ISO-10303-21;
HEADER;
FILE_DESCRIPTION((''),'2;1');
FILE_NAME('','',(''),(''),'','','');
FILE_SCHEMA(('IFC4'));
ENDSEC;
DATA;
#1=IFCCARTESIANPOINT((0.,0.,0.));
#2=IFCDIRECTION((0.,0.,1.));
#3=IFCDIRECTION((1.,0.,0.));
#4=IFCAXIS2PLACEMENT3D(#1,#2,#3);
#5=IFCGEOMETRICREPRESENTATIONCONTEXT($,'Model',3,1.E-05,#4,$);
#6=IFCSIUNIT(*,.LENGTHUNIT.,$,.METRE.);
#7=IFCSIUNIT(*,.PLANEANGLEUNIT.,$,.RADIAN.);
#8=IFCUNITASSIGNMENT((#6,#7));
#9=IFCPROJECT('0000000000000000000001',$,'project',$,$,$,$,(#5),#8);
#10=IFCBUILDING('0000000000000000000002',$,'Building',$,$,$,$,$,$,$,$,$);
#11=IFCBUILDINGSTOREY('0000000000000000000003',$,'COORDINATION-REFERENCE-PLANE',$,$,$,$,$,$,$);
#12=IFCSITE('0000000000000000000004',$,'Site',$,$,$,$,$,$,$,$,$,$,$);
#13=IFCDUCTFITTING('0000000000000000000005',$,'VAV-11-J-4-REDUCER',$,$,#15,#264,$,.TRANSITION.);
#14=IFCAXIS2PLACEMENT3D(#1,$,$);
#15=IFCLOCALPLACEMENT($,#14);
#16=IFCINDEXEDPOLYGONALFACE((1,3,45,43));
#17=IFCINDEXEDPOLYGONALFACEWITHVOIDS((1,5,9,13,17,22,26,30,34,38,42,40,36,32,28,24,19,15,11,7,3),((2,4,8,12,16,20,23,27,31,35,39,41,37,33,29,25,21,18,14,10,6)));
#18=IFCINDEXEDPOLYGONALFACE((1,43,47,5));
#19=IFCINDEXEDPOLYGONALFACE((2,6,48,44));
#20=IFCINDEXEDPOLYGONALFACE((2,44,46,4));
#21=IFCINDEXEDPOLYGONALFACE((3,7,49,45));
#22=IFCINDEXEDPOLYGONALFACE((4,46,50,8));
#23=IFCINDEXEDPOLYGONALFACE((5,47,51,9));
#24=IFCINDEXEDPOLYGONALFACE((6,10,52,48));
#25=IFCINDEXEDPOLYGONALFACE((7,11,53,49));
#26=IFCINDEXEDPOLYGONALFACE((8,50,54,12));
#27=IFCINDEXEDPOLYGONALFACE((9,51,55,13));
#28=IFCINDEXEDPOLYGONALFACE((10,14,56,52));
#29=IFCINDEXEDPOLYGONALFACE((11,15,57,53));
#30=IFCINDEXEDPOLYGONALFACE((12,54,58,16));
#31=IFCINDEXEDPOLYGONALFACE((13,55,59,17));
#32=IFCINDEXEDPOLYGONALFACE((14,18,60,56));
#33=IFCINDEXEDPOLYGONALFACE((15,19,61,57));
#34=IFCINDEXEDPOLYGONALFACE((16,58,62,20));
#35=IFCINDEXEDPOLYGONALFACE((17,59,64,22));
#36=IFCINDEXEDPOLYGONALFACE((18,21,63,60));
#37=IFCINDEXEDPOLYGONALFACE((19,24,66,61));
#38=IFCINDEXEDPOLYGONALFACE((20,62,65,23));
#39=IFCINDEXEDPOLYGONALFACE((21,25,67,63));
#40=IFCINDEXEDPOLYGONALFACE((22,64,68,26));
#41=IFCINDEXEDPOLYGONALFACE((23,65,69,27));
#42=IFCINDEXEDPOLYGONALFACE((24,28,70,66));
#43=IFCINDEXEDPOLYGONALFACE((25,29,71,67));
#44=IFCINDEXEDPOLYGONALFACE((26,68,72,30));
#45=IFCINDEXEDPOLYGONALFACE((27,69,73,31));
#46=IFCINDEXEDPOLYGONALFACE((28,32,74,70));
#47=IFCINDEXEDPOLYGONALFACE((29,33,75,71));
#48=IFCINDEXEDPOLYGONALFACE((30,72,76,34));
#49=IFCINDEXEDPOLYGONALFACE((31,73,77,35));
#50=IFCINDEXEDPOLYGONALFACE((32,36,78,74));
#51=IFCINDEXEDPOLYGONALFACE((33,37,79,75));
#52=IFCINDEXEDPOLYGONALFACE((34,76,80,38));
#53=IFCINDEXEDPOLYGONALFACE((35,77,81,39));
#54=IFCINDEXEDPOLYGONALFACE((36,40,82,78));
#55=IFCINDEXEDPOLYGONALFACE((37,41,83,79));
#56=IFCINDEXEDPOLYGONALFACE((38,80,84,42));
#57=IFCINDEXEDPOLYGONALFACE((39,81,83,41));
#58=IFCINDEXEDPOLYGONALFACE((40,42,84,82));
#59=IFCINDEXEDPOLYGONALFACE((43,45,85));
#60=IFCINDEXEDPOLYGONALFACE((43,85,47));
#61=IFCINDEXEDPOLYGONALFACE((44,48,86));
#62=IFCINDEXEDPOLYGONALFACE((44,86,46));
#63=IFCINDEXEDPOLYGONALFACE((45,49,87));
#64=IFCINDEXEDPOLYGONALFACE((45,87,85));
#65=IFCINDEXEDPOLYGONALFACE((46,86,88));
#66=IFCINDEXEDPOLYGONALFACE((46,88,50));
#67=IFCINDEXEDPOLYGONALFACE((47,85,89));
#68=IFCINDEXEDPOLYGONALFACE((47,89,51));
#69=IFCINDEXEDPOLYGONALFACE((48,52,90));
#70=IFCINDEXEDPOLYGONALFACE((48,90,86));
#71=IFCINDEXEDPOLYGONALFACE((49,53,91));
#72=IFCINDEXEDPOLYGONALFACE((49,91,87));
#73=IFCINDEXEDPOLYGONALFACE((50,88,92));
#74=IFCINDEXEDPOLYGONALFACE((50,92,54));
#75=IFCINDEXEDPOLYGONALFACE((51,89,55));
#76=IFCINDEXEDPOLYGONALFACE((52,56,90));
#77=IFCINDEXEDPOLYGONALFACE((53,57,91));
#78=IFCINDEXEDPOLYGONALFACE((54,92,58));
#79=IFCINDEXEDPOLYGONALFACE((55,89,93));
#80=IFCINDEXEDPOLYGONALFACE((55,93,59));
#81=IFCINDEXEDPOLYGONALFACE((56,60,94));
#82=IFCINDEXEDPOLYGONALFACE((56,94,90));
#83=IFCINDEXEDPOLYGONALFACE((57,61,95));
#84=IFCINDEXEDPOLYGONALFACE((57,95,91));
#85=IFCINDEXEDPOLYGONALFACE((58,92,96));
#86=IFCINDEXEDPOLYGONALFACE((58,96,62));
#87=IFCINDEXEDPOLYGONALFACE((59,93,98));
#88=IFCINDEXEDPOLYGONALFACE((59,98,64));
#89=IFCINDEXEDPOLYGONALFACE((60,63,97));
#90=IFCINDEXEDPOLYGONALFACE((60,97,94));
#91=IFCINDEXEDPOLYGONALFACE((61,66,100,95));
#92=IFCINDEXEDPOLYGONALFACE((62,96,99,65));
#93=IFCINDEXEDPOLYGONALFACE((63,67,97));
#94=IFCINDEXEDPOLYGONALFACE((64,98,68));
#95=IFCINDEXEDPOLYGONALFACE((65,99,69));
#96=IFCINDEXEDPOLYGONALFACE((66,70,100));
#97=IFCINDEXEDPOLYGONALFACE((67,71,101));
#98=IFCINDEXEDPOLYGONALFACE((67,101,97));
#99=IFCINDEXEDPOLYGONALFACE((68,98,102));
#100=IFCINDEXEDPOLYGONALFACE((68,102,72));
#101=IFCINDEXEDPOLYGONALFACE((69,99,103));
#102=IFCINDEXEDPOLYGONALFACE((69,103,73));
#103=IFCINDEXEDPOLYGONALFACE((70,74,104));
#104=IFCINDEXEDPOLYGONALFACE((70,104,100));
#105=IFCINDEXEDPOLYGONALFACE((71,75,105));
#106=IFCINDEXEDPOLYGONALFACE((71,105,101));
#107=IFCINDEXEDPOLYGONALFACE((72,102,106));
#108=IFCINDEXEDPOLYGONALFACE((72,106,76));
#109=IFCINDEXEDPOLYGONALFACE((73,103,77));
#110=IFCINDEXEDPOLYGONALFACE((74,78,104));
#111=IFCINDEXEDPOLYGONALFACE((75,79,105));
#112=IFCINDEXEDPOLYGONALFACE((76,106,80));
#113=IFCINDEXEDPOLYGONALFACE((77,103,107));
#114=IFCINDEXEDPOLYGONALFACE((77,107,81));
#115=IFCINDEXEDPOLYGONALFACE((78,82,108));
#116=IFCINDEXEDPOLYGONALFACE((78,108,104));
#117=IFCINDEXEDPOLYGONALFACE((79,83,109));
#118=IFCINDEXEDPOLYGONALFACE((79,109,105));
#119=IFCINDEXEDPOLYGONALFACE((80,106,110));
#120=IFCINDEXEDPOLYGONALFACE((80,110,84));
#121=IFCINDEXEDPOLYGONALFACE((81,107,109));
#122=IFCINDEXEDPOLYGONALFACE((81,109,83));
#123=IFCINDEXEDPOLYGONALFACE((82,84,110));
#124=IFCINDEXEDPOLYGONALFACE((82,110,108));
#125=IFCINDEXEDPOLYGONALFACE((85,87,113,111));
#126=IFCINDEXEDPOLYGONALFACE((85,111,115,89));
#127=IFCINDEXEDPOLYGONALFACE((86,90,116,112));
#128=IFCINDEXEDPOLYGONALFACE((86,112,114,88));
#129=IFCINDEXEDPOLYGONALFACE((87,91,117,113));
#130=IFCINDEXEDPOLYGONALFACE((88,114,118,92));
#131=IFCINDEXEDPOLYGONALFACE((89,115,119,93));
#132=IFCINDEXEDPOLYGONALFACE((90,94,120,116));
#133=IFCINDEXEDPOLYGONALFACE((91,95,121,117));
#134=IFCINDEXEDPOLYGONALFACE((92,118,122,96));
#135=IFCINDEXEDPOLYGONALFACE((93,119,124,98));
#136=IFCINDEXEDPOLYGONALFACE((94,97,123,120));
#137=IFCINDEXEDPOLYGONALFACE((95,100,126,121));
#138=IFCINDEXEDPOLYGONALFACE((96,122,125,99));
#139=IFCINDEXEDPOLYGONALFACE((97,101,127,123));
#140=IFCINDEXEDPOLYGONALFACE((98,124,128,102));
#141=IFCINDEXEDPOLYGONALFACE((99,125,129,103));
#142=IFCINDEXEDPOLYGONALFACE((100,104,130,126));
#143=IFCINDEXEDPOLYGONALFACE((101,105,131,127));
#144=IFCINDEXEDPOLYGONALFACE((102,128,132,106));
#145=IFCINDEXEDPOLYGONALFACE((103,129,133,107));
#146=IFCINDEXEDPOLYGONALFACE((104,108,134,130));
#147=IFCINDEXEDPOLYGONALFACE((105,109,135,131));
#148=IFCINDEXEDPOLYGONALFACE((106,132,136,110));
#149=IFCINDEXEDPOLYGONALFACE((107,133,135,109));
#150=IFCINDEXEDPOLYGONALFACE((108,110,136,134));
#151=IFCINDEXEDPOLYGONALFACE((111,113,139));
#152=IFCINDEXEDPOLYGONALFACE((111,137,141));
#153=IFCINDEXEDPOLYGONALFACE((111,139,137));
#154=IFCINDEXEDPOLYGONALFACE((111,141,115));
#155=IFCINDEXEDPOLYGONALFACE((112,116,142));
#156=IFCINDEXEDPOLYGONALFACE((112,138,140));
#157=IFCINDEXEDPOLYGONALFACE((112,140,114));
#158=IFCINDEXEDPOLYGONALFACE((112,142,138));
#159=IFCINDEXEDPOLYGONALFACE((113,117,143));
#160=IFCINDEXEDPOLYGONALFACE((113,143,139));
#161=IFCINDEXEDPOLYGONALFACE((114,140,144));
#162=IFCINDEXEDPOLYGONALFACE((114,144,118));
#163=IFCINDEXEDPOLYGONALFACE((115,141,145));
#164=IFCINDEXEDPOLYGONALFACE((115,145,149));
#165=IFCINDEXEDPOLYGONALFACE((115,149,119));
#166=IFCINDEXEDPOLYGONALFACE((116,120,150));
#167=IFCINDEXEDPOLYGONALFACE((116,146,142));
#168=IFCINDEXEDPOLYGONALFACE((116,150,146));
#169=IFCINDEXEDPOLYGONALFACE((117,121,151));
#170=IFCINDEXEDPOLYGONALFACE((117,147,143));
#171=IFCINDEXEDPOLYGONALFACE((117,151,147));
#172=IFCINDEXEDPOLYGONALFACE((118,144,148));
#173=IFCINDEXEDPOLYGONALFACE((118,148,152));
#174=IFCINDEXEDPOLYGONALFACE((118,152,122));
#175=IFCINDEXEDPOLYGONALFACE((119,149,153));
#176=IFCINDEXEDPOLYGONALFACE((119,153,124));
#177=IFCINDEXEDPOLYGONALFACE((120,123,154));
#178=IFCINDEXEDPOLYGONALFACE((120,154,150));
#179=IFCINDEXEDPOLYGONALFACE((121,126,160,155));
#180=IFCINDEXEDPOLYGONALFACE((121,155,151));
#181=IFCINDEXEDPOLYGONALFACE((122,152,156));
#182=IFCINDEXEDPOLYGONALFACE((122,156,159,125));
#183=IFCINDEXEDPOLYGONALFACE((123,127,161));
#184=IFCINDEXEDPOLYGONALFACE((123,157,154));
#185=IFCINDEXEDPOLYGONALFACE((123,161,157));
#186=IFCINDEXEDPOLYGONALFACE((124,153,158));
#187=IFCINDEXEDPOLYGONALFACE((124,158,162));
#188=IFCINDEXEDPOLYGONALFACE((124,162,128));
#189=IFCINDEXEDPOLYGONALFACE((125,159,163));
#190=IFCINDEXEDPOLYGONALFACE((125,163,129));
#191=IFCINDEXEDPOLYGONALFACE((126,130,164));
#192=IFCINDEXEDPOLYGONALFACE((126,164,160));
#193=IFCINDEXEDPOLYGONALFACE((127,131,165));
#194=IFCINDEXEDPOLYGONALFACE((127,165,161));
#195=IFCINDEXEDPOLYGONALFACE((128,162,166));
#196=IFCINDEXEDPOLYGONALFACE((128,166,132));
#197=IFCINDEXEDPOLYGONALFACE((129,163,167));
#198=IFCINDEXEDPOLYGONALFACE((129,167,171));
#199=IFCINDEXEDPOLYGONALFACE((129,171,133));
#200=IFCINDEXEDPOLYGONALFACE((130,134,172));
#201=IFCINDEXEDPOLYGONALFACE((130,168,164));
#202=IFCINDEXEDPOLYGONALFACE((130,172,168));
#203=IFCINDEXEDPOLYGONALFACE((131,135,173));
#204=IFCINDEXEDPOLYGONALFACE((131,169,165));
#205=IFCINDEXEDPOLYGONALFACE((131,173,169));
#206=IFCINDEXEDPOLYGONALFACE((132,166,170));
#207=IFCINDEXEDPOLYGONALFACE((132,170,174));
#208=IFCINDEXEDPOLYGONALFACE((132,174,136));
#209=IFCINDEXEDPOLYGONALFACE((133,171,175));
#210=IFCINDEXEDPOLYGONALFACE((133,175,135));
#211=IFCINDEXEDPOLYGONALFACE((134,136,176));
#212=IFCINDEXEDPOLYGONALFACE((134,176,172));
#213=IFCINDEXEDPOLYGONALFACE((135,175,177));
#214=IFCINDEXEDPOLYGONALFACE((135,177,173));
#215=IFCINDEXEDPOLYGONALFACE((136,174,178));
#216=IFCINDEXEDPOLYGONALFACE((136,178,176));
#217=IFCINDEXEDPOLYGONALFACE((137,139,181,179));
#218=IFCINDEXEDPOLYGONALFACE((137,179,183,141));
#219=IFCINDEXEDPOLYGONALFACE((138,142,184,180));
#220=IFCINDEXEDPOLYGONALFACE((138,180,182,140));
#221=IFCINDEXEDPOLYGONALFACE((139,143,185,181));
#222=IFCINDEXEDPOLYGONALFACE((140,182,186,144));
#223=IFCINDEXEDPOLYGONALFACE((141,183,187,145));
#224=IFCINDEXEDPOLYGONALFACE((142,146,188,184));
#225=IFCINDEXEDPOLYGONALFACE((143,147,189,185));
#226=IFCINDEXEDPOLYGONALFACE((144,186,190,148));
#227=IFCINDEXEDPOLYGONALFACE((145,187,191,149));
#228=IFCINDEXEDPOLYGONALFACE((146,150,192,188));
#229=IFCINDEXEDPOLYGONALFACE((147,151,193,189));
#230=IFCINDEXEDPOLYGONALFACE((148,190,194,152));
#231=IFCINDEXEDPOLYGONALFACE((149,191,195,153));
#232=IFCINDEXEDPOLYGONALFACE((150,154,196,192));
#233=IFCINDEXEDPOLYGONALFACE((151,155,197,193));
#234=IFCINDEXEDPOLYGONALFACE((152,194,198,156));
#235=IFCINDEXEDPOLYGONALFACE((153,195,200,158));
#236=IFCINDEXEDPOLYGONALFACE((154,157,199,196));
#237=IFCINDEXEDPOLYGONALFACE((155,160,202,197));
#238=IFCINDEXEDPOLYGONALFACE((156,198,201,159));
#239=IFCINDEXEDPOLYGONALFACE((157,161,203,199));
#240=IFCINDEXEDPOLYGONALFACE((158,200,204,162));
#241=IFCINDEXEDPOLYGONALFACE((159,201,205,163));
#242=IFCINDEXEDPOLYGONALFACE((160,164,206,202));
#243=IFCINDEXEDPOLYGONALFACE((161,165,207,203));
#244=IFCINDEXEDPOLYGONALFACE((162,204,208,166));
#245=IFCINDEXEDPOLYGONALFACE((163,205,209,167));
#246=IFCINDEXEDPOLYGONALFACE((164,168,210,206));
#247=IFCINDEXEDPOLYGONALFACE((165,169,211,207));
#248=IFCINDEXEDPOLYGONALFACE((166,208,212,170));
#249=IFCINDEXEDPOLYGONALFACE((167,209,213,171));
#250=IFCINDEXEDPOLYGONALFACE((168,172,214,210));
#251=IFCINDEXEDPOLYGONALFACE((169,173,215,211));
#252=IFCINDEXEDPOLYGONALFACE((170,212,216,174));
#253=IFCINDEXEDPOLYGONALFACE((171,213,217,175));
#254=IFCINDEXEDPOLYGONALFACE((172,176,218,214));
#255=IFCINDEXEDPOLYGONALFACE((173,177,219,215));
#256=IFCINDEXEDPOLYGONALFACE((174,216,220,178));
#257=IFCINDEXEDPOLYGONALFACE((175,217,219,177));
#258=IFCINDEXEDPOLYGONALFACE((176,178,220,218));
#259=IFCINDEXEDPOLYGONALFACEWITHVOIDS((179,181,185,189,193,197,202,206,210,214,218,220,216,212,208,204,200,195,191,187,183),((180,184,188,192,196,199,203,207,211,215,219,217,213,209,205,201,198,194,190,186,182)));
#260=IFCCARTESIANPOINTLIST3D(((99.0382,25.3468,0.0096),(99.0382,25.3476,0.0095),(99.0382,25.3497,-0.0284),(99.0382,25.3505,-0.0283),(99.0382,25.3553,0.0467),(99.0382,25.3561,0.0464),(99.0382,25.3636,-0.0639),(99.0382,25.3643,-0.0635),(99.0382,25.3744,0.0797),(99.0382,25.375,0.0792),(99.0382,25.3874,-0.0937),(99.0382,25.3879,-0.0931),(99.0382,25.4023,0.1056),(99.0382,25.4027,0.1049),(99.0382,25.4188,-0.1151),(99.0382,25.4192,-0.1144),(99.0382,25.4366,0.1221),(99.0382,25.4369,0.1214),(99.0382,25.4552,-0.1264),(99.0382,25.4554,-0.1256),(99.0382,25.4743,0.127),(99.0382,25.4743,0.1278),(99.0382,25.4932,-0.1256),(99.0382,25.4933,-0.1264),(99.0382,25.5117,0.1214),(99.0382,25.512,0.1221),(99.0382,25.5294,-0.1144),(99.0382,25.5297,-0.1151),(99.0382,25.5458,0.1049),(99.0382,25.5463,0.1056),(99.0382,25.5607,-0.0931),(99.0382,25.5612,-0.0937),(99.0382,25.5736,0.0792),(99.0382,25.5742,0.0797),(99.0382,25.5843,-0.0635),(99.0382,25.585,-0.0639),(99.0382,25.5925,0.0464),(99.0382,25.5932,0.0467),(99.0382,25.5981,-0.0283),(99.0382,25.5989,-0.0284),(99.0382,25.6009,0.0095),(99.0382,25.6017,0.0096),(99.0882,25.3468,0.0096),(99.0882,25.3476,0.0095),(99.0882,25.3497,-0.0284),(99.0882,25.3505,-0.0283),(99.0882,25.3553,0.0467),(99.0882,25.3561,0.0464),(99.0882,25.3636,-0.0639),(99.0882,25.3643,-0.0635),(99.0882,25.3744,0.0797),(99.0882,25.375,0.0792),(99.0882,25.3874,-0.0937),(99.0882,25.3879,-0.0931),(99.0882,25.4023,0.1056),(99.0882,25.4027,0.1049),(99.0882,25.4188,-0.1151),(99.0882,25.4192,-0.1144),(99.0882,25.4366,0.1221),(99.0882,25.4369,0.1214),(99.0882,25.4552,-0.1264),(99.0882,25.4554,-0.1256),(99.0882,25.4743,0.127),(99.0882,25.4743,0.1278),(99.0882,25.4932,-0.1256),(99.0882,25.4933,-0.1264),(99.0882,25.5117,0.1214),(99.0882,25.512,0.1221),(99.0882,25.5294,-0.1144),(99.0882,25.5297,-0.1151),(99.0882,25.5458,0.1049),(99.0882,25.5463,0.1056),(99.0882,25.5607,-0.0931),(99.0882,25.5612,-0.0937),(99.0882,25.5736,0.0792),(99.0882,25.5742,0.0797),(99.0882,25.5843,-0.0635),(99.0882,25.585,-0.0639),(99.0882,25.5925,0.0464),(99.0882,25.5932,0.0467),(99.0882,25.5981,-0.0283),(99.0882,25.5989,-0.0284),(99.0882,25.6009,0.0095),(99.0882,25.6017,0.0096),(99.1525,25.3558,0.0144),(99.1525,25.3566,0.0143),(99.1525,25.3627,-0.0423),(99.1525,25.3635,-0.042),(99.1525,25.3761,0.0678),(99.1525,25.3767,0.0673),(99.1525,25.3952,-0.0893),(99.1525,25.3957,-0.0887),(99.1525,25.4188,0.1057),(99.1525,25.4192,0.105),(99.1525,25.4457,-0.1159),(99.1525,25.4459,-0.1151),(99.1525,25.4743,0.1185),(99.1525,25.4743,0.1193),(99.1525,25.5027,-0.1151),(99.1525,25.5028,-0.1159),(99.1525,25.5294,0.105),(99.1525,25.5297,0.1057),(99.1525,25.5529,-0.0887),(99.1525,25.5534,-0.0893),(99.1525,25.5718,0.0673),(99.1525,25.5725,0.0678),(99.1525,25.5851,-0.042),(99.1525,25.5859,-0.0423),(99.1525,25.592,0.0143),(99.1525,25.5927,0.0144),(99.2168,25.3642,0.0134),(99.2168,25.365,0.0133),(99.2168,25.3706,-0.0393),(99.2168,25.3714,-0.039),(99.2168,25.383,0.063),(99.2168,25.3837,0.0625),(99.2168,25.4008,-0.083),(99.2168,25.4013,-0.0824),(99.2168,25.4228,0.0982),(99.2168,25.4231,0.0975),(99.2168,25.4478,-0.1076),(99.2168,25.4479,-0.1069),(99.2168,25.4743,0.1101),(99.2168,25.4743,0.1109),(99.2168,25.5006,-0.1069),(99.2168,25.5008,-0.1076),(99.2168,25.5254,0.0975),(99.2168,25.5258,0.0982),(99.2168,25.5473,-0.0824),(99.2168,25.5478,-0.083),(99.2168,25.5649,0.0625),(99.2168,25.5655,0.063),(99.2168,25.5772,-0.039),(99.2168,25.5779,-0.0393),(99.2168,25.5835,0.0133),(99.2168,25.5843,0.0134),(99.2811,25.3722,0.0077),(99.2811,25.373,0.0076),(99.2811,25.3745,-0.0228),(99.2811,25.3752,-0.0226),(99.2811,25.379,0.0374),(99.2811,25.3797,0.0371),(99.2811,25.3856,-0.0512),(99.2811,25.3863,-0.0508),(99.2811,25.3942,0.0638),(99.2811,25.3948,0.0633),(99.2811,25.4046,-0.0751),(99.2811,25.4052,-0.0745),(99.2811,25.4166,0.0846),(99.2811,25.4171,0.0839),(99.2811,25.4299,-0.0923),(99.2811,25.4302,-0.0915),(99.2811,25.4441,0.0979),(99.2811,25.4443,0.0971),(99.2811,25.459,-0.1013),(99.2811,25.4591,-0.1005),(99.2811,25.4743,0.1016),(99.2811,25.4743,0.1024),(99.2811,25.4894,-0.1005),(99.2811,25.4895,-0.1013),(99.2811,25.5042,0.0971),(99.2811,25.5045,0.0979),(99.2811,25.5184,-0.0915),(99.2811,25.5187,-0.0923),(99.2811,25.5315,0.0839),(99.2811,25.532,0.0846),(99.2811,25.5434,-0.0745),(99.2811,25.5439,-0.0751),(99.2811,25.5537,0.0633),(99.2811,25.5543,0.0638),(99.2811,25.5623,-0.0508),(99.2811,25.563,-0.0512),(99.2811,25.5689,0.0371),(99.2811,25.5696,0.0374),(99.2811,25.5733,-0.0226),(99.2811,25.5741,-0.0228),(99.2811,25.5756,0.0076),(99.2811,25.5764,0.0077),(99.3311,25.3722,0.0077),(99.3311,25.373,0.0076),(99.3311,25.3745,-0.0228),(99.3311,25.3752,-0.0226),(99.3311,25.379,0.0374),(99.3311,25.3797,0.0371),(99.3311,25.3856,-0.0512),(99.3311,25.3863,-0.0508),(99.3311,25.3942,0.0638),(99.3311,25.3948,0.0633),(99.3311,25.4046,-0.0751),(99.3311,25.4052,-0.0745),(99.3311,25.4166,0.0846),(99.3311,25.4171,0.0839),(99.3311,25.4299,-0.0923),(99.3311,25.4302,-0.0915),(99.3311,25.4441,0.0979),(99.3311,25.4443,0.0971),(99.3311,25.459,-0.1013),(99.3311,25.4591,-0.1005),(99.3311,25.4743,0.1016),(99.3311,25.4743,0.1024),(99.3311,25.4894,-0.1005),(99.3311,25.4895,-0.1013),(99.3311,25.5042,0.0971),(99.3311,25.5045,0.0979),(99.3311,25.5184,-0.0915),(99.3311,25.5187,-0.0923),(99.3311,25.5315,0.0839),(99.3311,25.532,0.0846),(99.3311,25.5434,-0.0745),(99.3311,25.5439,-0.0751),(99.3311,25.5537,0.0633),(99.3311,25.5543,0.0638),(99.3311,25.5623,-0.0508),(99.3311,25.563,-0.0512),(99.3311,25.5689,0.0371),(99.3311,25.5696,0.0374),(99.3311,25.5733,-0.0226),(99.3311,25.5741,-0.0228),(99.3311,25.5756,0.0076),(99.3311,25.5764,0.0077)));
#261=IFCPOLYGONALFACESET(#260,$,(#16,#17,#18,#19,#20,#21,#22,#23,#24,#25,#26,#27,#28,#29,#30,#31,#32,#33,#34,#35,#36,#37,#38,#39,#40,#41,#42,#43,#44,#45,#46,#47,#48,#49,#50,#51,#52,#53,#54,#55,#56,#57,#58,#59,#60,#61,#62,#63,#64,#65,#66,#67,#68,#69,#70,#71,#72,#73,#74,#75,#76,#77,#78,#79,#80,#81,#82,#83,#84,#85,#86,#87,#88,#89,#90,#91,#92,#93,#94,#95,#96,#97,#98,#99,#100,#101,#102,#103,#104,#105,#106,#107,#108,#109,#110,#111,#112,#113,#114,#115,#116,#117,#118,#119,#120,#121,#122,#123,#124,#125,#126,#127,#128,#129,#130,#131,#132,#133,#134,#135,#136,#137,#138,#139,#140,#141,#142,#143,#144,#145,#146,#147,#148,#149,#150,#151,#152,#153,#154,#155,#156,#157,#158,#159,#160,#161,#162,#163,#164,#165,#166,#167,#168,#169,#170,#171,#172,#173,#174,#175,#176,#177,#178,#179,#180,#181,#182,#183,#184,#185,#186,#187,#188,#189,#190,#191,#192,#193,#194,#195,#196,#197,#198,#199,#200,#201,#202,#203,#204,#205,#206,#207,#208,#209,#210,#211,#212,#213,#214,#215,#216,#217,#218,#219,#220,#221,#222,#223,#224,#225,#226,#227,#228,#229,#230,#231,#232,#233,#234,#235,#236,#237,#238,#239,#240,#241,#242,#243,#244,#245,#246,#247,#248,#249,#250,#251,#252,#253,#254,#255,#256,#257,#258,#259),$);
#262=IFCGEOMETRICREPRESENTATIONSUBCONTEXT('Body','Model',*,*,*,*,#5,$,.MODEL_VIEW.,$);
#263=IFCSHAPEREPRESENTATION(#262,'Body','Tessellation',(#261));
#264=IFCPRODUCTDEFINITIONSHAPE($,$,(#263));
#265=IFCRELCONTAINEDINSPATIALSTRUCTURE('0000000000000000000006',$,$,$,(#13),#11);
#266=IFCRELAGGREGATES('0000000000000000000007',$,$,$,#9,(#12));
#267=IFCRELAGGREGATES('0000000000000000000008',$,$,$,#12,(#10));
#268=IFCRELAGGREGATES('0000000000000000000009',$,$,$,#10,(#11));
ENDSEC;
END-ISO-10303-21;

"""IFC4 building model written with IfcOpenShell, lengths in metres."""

from ifc_helpers import new_model, entity, si_unit, frame, origin_with_axes, place, context, subcontext, project, spatial, element, save


model = new_model("IFC4")

# Units and contexts
model_context = context("Model", 3, precision=1e-05, world=origin_with_axes())
body_context_1 = subcontext(model_context, "Body", "Model", "MODEL_VIEW")
ifc_project = project(units=[si_unit("LENGTHUNIT", "METRE"), si_unit("PLANEANGLEUNIT", "RADIAN")], contexts=[model_context])

# Site, building, storey
site = spatial("IfcSite", under=ifc_project, Name="Site")
building = spatial("IfcBuilding", under=site, Name="Building")
storey = spatial("IfcBuildingStorey", under=building, Name="COORDINATION-REFERENCE-PLANE")

# Duct fitting
for number, where, z_axis, x_axis, name in (
    (1, (99.0382, 25.4743, 0.0), (0.0, 1.0, 0.0), (0.0, 0.0, 1.0), "VAV-11-J-4-REDUCER"),
):
    element("IfcDuctFitting", number, at=place(None, frame(where, z_axis=z_axis, x_axis=x_axis)), inside=storey, Name=name, PredefinedType="TRANSITION", context=body_context_1, shape_type="SweptSolid", body=[
        entity("IfcRevolvedAreaSolid", entity("IfcArbitraryClosedProfileDef", "AREA", None, entity("IfcPolyline", [entity("IfcCartesianPoint", [0.1278, 0.0]), entity("IfcCartesianPoint", [0.1278, 0.05]), entity("IfcCartesianPoint", [0.1024, 0.2429]), entity("IfcCartesianPoint", [0.1024, 0.2929]), entity("IfcCartesianPoint", [0.1016, 0.2929]), entity("IfcCartesianPoint", [0.1016, 0.2429]), entity("IfcCartesianPoint", [0.127, 0.05]), entity("IfcCartesianPoint", [0.127, 0.0]), entity("IfcCartesianPoint", [0.1278, 0.0])])), entity("IfcAxis2Placement3D", entity("IfcCartesianPoint", [0.0, 0.0, 0.0])), entity("IfcAxis1Placement", entity("IfcCartesianPoint", [0.0, 0.0, 0.0]), entity("IfcDirection", [0.0, 1.0, 0.0])), 6.283185),
    ])

save(model, "model.ifc")
